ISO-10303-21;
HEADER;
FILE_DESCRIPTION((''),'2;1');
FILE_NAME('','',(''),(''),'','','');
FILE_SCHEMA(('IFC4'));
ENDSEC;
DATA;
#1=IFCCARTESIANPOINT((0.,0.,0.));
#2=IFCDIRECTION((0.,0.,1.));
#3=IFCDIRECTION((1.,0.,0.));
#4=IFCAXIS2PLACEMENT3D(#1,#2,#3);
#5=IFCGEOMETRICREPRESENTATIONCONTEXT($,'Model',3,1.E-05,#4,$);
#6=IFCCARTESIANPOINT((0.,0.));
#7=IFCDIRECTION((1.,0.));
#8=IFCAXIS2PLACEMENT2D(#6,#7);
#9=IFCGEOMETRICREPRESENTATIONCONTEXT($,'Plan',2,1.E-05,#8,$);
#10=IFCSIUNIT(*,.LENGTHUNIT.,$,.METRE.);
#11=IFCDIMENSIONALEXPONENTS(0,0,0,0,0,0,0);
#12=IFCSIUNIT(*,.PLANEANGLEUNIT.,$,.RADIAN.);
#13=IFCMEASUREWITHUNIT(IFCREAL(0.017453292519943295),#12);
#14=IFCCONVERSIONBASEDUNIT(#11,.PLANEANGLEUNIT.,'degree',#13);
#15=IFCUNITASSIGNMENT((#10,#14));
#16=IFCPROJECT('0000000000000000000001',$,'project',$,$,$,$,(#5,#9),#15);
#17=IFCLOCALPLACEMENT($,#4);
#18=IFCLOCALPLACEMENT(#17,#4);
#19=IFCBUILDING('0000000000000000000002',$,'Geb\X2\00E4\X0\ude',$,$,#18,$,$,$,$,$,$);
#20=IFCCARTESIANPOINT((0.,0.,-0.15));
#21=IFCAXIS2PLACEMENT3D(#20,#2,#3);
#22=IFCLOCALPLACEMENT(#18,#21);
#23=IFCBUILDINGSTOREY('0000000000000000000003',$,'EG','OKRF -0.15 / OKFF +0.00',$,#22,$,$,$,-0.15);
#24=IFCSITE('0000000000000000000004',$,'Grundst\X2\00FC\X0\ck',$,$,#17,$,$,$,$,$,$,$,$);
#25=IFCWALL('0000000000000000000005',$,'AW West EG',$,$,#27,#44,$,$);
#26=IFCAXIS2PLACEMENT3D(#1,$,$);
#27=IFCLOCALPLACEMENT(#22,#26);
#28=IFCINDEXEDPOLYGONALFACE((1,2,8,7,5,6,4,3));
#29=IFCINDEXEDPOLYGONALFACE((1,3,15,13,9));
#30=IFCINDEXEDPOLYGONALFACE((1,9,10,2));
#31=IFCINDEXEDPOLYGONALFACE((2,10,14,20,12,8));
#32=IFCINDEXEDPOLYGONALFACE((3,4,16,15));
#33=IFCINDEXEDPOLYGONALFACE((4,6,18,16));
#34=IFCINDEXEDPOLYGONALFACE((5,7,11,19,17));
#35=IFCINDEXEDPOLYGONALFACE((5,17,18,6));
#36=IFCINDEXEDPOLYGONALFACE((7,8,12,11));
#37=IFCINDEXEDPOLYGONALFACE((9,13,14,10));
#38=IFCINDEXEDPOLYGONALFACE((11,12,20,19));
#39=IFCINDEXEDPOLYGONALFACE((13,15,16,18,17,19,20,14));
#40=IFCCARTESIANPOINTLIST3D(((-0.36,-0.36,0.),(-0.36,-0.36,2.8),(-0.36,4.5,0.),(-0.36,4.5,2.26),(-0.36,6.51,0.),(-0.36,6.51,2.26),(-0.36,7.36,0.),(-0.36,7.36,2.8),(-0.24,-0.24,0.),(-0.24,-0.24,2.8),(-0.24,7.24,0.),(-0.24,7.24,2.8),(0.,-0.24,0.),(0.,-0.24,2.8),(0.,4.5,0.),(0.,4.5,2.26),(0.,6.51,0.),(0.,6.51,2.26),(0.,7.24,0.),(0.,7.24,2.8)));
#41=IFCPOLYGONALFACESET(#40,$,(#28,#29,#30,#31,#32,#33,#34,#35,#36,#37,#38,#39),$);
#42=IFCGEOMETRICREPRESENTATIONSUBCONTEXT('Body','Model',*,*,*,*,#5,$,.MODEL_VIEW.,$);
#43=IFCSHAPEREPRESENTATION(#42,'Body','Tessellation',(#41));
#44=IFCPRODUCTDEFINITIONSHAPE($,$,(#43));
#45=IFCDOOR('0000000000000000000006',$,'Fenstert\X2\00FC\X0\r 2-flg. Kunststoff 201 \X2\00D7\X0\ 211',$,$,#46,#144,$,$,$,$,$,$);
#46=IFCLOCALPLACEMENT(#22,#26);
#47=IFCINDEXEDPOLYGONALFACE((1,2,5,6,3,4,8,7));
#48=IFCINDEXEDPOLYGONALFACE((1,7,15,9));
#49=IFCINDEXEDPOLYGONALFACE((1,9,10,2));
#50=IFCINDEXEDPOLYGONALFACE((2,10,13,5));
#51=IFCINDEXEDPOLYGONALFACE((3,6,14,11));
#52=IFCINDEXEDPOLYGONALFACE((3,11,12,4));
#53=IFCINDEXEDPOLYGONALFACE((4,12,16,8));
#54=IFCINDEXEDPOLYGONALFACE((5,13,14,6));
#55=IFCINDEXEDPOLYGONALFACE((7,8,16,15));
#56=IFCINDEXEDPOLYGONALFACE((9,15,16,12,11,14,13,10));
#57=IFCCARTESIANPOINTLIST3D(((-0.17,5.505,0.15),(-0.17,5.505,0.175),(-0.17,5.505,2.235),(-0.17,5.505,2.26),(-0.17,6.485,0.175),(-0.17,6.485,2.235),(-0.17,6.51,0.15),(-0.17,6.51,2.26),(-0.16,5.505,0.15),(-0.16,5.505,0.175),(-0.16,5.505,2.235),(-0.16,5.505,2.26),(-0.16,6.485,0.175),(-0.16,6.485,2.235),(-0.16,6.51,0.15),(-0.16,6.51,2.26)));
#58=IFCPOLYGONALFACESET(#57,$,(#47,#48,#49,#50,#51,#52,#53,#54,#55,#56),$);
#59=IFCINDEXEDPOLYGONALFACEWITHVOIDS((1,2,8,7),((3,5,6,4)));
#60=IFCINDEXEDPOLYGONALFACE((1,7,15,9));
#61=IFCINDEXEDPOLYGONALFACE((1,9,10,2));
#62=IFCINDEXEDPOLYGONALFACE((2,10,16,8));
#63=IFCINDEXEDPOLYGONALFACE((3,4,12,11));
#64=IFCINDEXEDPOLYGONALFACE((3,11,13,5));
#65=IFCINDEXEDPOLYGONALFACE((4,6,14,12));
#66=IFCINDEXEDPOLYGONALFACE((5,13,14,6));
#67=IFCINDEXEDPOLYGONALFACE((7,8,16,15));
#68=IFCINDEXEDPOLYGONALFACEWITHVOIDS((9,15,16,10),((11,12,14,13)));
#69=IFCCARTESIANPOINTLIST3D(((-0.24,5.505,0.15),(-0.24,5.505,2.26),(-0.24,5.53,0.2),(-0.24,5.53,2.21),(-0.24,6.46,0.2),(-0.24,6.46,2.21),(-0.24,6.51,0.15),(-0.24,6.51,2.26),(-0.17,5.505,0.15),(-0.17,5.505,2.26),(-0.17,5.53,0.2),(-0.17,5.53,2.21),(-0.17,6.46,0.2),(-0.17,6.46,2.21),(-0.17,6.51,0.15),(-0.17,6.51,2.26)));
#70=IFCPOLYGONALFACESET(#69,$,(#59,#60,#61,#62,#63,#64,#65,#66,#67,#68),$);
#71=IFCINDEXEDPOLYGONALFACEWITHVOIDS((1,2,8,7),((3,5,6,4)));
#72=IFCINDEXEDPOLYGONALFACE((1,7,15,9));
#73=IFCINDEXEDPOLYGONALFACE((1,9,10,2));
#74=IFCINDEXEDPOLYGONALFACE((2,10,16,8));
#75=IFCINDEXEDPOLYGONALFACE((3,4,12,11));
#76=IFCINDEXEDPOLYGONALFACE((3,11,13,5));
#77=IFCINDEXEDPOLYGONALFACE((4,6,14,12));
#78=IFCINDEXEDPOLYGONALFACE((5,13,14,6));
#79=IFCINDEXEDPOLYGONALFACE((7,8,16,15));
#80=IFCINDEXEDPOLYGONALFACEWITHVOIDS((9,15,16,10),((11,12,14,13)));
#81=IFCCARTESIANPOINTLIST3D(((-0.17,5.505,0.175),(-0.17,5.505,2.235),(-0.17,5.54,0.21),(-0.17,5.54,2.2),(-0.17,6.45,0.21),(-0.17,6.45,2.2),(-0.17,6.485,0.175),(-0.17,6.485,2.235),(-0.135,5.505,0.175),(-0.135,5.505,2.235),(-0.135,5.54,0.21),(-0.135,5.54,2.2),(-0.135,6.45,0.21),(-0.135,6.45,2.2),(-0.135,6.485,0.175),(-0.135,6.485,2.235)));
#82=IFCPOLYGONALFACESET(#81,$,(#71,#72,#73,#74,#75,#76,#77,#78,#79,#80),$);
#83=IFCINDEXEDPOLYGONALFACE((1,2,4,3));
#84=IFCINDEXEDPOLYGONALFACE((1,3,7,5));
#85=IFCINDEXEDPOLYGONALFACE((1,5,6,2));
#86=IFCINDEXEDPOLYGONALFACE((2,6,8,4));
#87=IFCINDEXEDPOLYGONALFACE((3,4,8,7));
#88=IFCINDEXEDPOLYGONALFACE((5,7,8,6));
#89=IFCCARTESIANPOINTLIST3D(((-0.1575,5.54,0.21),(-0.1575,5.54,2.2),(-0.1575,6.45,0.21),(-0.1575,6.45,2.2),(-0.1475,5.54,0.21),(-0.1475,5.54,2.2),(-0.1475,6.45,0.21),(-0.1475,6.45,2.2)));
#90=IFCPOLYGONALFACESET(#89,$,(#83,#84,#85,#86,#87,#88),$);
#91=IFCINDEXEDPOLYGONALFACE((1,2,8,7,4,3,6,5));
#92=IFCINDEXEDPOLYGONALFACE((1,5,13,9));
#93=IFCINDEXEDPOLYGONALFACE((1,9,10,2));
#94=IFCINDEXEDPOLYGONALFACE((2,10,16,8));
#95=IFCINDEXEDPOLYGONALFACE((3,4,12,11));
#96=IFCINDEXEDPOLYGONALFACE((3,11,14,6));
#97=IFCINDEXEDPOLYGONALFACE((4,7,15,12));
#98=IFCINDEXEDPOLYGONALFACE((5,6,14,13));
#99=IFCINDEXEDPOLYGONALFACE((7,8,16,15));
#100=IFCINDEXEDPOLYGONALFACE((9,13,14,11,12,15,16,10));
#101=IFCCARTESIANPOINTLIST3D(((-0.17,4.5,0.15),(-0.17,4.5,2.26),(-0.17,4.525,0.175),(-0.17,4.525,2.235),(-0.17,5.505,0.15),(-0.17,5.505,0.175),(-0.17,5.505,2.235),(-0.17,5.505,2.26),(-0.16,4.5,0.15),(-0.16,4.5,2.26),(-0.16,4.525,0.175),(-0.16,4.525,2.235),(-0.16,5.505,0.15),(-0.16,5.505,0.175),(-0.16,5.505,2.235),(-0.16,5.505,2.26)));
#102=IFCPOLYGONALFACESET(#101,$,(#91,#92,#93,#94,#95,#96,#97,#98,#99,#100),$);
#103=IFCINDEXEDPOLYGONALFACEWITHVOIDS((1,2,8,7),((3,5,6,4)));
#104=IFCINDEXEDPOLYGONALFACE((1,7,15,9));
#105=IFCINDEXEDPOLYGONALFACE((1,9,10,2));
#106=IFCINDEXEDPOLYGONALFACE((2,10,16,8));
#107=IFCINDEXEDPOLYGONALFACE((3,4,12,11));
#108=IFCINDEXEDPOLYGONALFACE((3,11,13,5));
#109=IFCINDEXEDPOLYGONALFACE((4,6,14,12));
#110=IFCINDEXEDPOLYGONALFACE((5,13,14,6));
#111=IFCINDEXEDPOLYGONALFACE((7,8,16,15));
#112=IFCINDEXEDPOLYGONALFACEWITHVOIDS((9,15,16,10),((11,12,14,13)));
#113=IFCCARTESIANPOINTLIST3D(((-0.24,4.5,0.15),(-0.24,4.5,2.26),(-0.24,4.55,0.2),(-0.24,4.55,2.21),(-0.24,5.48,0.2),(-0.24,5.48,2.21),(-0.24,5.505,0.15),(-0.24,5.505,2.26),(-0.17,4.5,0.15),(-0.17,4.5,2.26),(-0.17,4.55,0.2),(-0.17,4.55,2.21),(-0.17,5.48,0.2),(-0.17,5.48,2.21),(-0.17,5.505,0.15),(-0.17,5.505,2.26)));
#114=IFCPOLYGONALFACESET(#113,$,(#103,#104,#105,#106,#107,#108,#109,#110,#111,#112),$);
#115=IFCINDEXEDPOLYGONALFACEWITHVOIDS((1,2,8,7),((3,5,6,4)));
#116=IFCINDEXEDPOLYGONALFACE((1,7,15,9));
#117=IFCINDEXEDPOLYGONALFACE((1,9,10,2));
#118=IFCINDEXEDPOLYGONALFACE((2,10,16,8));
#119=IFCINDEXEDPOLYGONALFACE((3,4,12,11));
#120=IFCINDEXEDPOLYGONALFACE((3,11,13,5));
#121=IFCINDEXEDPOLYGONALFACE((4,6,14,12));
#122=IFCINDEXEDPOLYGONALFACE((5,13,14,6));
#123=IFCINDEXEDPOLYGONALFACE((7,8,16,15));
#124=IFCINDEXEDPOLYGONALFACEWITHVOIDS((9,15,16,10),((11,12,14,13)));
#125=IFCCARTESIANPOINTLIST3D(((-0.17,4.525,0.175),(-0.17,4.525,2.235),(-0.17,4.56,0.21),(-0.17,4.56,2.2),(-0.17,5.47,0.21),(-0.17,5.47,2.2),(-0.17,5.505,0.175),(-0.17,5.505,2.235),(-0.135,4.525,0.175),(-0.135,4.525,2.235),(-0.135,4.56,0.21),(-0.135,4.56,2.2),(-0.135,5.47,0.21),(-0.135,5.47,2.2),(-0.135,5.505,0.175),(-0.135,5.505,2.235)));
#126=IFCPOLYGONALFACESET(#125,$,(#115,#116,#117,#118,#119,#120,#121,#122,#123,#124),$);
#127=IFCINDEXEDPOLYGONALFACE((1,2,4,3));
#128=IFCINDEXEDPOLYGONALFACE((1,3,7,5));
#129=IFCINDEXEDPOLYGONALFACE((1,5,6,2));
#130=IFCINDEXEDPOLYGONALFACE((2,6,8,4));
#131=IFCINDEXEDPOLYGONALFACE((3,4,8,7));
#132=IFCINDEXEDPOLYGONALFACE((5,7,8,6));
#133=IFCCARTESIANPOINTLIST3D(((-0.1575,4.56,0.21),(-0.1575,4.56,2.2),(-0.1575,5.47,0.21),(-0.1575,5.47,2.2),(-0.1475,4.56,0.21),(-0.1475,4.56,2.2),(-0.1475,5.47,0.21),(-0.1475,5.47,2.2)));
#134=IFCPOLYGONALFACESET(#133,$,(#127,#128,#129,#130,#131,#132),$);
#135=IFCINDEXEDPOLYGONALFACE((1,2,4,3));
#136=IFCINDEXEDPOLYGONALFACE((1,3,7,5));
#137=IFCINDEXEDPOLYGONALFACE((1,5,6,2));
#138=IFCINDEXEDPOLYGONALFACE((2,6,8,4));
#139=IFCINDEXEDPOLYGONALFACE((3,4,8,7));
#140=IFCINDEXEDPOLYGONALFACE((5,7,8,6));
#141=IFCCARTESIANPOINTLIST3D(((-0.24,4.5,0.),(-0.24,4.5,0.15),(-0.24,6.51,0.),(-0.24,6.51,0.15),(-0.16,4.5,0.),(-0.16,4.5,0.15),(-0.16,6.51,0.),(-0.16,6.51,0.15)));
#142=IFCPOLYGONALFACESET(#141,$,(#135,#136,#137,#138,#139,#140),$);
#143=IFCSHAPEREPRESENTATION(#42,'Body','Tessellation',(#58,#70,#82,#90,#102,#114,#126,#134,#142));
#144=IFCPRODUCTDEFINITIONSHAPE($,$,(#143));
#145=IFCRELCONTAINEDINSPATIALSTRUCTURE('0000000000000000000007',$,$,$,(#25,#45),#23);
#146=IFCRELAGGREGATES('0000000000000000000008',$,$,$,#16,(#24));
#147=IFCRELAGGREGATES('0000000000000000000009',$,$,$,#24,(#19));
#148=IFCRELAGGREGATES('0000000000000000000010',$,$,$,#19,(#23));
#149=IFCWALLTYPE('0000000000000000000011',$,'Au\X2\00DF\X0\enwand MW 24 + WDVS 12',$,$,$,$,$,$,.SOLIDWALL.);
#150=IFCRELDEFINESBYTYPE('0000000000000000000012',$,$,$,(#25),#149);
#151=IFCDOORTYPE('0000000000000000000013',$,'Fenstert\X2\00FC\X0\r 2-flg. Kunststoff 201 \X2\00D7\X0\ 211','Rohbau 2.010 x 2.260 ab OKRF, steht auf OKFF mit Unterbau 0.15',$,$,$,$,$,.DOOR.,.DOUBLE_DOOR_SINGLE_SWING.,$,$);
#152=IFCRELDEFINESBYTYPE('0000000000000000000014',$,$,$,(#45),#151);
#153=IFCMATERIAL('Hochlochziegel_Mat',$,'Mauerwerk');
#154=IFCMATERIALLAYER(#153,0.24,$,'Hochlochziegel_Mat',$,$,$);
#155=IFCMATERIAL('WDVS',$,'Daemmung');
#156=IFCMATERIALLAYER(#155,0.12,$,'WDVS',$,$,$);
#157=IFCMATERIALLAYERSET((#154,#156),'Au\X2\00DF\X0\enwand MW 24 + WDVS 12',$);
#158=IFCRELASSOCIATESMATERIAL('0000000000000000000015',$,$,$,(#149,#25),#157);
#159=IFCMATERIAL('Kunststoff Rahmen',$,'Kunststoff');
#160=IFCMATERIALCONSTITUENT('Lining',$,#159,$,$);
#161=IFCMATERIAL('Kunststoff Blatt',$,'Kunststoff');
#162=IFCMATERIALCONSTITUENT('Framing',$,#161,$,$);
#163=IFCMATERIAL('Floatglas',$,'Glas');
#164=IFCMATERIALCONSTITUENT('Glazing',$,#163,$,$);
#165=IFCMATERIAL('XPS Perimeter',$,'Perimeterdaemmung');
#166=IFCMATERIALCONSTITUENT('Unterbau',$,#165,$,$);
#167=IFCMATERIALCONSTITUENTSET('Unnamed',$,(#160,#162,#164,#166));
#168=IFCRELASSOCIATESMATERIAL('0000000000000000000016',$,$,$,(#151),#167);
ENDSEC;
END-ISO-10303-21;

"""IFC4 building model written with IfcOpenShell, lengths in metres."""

from ifc_helpers import new_model, entity, si_unit, converted_unit, frame, origin_with_axes, origin_2d_with_axis, place, context, subcontext, project, spatial, line, indexed_curve, outline, extrude, shape, source, transform, mapped, material, layer, layer_set, layer_usage, constituent, constituent_set, type_object, type_shapes, element, fill, save


model = new_model("IFC4")

# Units and contexts
model_context = context("Model", 3, precision=1e-05, world=origin_with_axes())
plan_context = context("Plan", 2, precision=1e-05, world=origin_2d_with_axis())
body_context_1 = subcontext(model_context, "Body", "Model", "MODEL_VIEW")
body_context_2 = subcontext(plan_context, "Body", "Plan", "PLAN_VIEW")
ifc_project = project(units=[si_unit("LENGTHUNIT", "METRE"), converted_unit("PLANEANGLEUNIT", "degree", entity("IfcReal", 0.017453292519943295), si_unit("PLANEANGLEUNIT", "RADIAN"), dimensions=[0, 0, 0, 0, 0, 0, 0])], contexts=[model_context, plan_context])

# Site, building, storey
site_placement = place(None, origin_with_axes())
site = spatial("IfcSite", under=ifc_project, at=site_placement, Name="Grundstück")
building_placement = place(site_placement, origin_with_axes())
building = spatial("IfcBuilding", under=site, at=building_placement, Name="Gebäude")
storey_placement = place(building_placement, frame((0.0, 0.0, -0.15), z_axis=(0.0, 0.0, 1.0), x_axis=(1.0, 0.0, 0.0)))
storey = spatial("IfcBuildingStorey", under=building, at=storey_placement, Name="EG", Description="OKRF -0.15 / OKFF +0.00", Elevation=-0.15)

# Wall, opening, door
ifc_material_1 = material(Name="Hochlochziegel_Mat", Category="Mauerwerk")
ifc_layer_1 = layer(ifc_material_1, 0.24, Name="Hochlochziegel_Mat")
ifc_material_2 = material(Name="WDVS", Category="Daemmung")
ifc_layer_2 = layer(ifc_material_2, 0.12, Name="WDVS")
ifc_layer_set_1 = layer_set([ifc_layer_1, ifc_layer_2], Name="Außenwand MW 24 + WDVS 12")
ifc_layer_usage_1 = layer_usage(ifc_layer_set_1, "AXIS2", "POSITIVE", 0.0)
wall_type = type_object("IfcWallType", Name="Außenwand MW 24 + WDVS 12", PredefinedType="SOLIDWALL", material=ifc_layer_set_1)
wall_placement = place(storey_placement, frame((0.0, 0.0, 0.0), z_axis=(0.0, 0.0, 1.0), x_axis=(0.0, 1.0, 0.0)))
wall = element("IfcWall", 1, at=wall_placement, inside=storey, type_object=wall_type, material=ifc_layer_usage_1, Name="AW West EG", context=body_context_1, shape_type="SweptSolid", body=[
    extrude(outline(indexed_curve([(0.0, 0.0), (-0.24, 0.0), (-0.24, 0.24), (-0.36, 0.36), (7.36, 0.36), (7.24, 0.24), (7.24, 0.0), (7.0, 0.0)], segments=[line(1, 2, 3, 4, 5, 6, 7, 8, 1)])), origin_with_axes(), (0.0, 0.0, 1.0), 2.8),
])
opening_1_placement = place(wall_placement, frame((4.5, -0.05, 0.0), z_axis=(0.0, 0.0, 1.0), x_axis=(1.0, 0.0, 0.0)))
opening_1 = element("IfcOpeningElement", 2, at=opening_1_placement, cuts=wall, context=body_context_1, shape_type="SweptSolid", body=[
    extrude(outline(indexed_curve([(0.0, 0.0), (0.0, 0.46), (2.01, 0.46), (2.01, 0.0), (0.0, 0.0)], self_intersect=False)), origin_with_axes(), (0.0, 0.0, 1.0), 2.26),
])
ifc_material_3 = material(Name="Kunststoff Rahmen", Category="Kunststoff")
ifc_constituent_1 = constituent(ifc_material_3, Name="Lining")
ifc_material_4 = material(Name="Kunststoff Blatt", Category="Kunststoff")
ifc_constituent_2 = constituent(ifc_material_4, Name="Framing")
ifc_material_5 = material(Name="Floatglas", Category="Glas")
ifc_constituent_3 = constituent(ifc_material_5, Name="Glazing")
ifc_material_6 = material(Name="XPS Perimeter", Category="Perimeterdaemmung")
ifc_constituent_4 = constituent(ifc_material_6, Name="Unterbau")
ifc_constituent_set = constituent_set(constituents=[ifc_constituent_1, ifc_constituent_2, ifc_constituent_3, ifc_constituent_4], Name="Unnamed")
door_type = type_object("IfcDoorType", Name="Fenstertür 2-flg. Kunststoff 201 × 211", Description="Rohbau 2.010 x 2.260 ab OKRF, steht auf OKFF mit Unterbau 0.15", OperationType="DOUBLE_DOOR_SINGLE_SWING", PredefinedType="DOOR", material=ifc_constituent_set)
shared_shape_1 = source(origin_with_axes(), body_context_1, "Body", "SweptSolid", [
    extrude(outline(indexed_curve([(1.005, 0.0), (0.0, 0.0), (0.0, 2.11), (1.005, 2.11), (1.005, 2.085), (0.025, 2.085), (0.025, 0.025), (1.005, 0.025)], segments=[line(1, 2, 3, 4, 5, 6, 7, 8, 1)])), frame((0.0, 0.19, 0.15), z_axis=(0.0, -1.0, 0.0), x_axis=(1.0, 0.0, 0.0)), (0.0, 0.0, -1.0), 0.01),
    extrude(outline(indexed_curve([(0.0, 0.0), (1.005, 0.0), (1.005, 2.11), (0.0, 2.11)], segments=[line(1, 2, 3, 4, 1)]), holes=[indexed_curve([(0.05, 0.05), (0.98, 0.05), (0.98, 2.06), (0.05, 2.06)], segments=[line(1, 2, 3, 4, 1)])]), frame((0.0, 0.12, 0.15), z_axis=(0.0, -1.0, 0.0), x_axis=(1.0, 0.0, 0.0)), (0.0, 0.0, -1.0), 0.07),
    extrude(outline(indexed_curve([(0.0, 0.0), (0.98, 0.0), (0.98, 2.06), (0.0, 2.06)], segments=[line(1, 2, 3, 4, 1)]), holes=[indexed_curve([(0.035, 0.035), (0.945, 0.035), (0.945, 2.025), (0.035, 2.025)], segments=[line(1, 2, 3, 4, 1)])]), frame((0.025, 0.19, 0.175), z_axis=(0.0, -1.0, 0.0), x_axis=(1.0, 0.0, 0.0)), (0.0, 0.0, -1.0), 0.035),
    extrude(outline(indexed_curve([(0.035, 0.035), (0.945, 0.035), (0.945, 2.025), (0.035, 2.025)], segments=[line(1, 2, 3, 4, 1)])), frame((0.025, 0.2025, 0.175), z_axis=(0.0, -1.0, 0.0), x_axis=(1.0, 0.0, 0.0)), (0.0, 0.0, -1.0), 0.01),
    extrude(outline(indexed_curve([(0.0, 2.11), (1.005, 2.11), (1.005, 0.0), (0.0, 0.0), (0.0, 0.025), (0.98, 0.025), (0.98, 2.085), (0.0, 2.085)], segments=[line(1, 2, 3, 4, 5, 6, 7, 8, 1)])), frame((1.005, 0.19, 0.15), z_axis=(0.0, -1.0, 0.0), x_axis=(1.0, 0.0, 0.0)), (0.0, 0.0, -1.0), 0.01),
    extrude(outline(indexed_curve([(0.0, 0.0), (1.005, 0.0), (1.005, 2.11), (0.0, 2.11)], segments=[line(1, 2, 3, 4, 1)]), holes=[indexed_curve([(0.025, 0.05), (0.955, 0.05), (0.955, 2.06), (0.025, 2.06)], segments=[line(1, 2, 3, 4, 1)])]), frame((1.005, 0.12, 0.15), z_axis=(0.0, -1.0, 0.0), x_axis=(1.0, 0.0, 0.0)), (0.0, 0.0, -1.0), 0.07),
    extrude(outline(indexed_curve([(0.0, 0.0), (0.98, 0.0), (0.98, 2.06), (0.0, 2.06)], segments=[line(1, 2, 3, 4, 1)]), holes=[indexed_curve([(0.035, 0.035), (0.945, 0.035), (0.945, 2.025), (0.035, 2.025)], segments=[line(1, 2, 3, 4, 1)])]), frame((1.005, 0.19, 0.175), z_axis=(0.0, -1.0, 0.0), x_axis=(1.0, 0.0, 0.0)), (0.0, 0.0, -1.0), 0.035),
    extrude(outline(indexed_curve([(0.035, 0.035), (0.945, 0.035), (0.945, 2.025), (0.035, 2.025)], segments=[line(1, 2, 3, 4, 1)])), frame((1.005, 0.2025, 0.175), z_axis=(0.0, -1.0, 0.0), x_axis=(1.0, 0.0, 0.0)), (0.0, 0.0, -1.0), 0.01),
    extrude(outline(indexed_curve([(0.0, 0.0), (2.01, 0.0), (2.01, 0.08), (0.0, 0.08)], segments=[line(1, 2, 3, 4, 1)])), frame((0.0, 0.12, 0.0), z_axis=(0.0, 0.0, 1.0), x_axis=(1.0, 0.0, 0.0)), (0.0, 0.0, 1.0), 0.15),
])
shared_shape_2 = source(origin_with_axes(), body_context_2, "Body", "Curve2D", [
    entity("IfcIndexedPolyCurve", entity("IfcCartesianPointList2D", [[0.05, 0.12], [0.98, 0.12]])),
    entity("IfcIndexedPolyCurve", entity("IfcCartesianPointList2D", [[0.0, 0.2], [0.025, 0.2], [0.025, 0.19], [0.05, 0.19], [0.05, 0.12], [0.0, 0.12]]), [entity("IfcLineIndex", [1, 2, 3, 4, 5, 6, 1])]),
    entity("IfcIndexedPolyCurve", entity("IfcCartesianPointList2D", [[1.005, 0.2], [1.005, 0.2], [1.005, 0.19], [0.98, 0.19], [0.98, 0.12], [1.005, 0.12]])),
    entity("IfcIndexedPolyCurve", entity("IfcCartesianPointList2D", [[0.025, 0.19], [0.06, 0.19], [0.06, 0.225], [0.025, 0.225]]), [entity("IfcLineIndex", [1, 2, 3, 4, 1])]),
    entity("IfcIndexedPolyCurve", entity("IfcCartesianPointList2D", [[1.005, 0.19], [0.97, 0.19], [0.97, 0.225], [1.005, 0.225]]), [entity("IfcLineIndex", [1, 2, 3, 4, 1])]),
    entity("IfcIndexedPolyCurve", entity("IfcCartesianPointList2D", [[0.06, 0.19], [0.97, 0.19]])),
    entity("IfcIndexedPolyCurve", entity("IfcCartesianPointList2D", [[0.06, 0.225], [0.97, 0.225]])),
    entity("IfcIndexedPolyCurve", entity("IfcCartesianPointList2D", [[0.06, 0.2075], [0.97, 0.2075]])),
    entity("IfcIndexedPolyCurve", entity("IfcCartesianPointList2D", [[1.03, 0.12], [1.96, 0.12]])),
    entity("IfcIndexedPolyCurve", entity("IfcCartesianPointList2D", [[1.005, 0.2], [1.005, 0.2], [1.005, 0.19], [1.03, 0.19], [1.03, 0.12], [1.005, 0.12]])),
    entity("IfcIndexedPolyCurve", entity("IfcCartesianPointList2D", [[2.01, 0.2], [1.985, 0.2], [1.985, 0.19], [1.96, 0.19], [1.96, 0.12], [2.01, 0.12]]), [entity("IfcLineIndex", [1, 2, 3, 4, 5, 6, 1])]),
    entity("IfcIndexedPolyCurve", entity("IfcCartesianPointList2D", [[1.005, 0.19], [1.04, 0.19], [1.04, 0.225], [1.005, 0.225]]), [entity("IfcLineIndex", [1, 2, 3, 4, 1])]),
    entity("IfcIndexedPolyCurve", entity("IfcCartesianPointList2D", [[1.985, 0.19], [1.95, 0.19], [1.95, 0.225], [1.985, 0.225]]), [entity("IfcLineIndex", [1, 2, 3, 4, 1])]),
    entity("IfcIndexedPolyCurve", entity("IfcCartesianPointList2D", [[1.04, 0.19], [1.95, 0.19]])),
    entity("IfcIndexedPolyCurve", entity("IfcCartesianPointList2D", [[1.04, 0.225], [1.95, 0.225]])),
    entity("IfcIndexedPolyCurve", entity("IfcCartesianPointList2D", [[1.04, 0.2075], [1.95, 0.2075]])),
    entity("IfcTrimmedCurve", entity("IfcEllipse", entity("IfcAxis2Placement2D", entity("IfcCartesianPoint", [0.06, 0.2]), entity("IfcDirection", [1.0, 0.0])), 0.945, 0.98), [entity("IfcCartesianPoint", [1.005, 0.2])], [entity("IfcCartesianPoint", [0.06, 1.18])], True, "CARTESIAN"),
    entity("IfcIndexedPolyCurve", entity("IfcCartesianPointList2D", [[0.025, 0.2], [0.06, 0.2], [0.06, 1.18], [0.025, 1.18]]), [entity("IfcLineIndex", [1, 2, 3, 4, 1])]),
    entity("IfcTrimmedCurve", entity("IfcEllipse", entity("IfcAxis2Placement2D", entity("IfcCartesianPoint", [1.95, 0.2]), entity("IfcDirection", [1.0, 0.0])), 0.945, 0.98), [entity("IfcCartesianPoint", [1.95, 1.18])], [entity("IfcCartesianPoint", [1.005, 0.2])], True, "CARTESIAN"),
    entity("IfcIndexedPolyCurve", entity("IfcCartesianPointList2D", [[1.985, 0.2], [1.95, 0.2], [1.95, 1.18], [1.985, 1.18]]), [entity("IfcLineIndex", [1, 2, 3, 4, 1])]),
])
type_shapes(door_type, [shared_shape_1, shared_shape_2])
door_placement = place(storey_placement, frame((-0.36, 6.51, 0.0), z_axis=(0.0, 0.0, 1.0), x_axis=(0.0, -1.0, 0.0)))
door = element("IfcDoor", 3, at=door_placement, inside=storey, type_object=door_type, Name="Fenstertür 2-flg. Kunststoff 201 × 211", shapes=[
    shape(body_context_1, "Body", "MappedRepresentation", [mapped(shared_shape_1, transform((0.0, 0.0, 0.0), x_axis=(1.0, 0.0, 0.0), y_axis=(0.0, 1.0, 0.0), z_axis=(0.0, 0.0, 1.0), scale=1.0))]),
    shape(body_context_2, "Body", "MappedRepresentation", [mapped(shared_shape_2, transform((0.0, 0.0, 0.0), x_axis=(1.0, 0.0, 0.0), y_axis=(0.0, 1.0, 0.0), z_axis=(0.0, 0.0, 1.0), scale=1.0))]),
])
fill(opening_1, door)

save(model, "model.ifc")
